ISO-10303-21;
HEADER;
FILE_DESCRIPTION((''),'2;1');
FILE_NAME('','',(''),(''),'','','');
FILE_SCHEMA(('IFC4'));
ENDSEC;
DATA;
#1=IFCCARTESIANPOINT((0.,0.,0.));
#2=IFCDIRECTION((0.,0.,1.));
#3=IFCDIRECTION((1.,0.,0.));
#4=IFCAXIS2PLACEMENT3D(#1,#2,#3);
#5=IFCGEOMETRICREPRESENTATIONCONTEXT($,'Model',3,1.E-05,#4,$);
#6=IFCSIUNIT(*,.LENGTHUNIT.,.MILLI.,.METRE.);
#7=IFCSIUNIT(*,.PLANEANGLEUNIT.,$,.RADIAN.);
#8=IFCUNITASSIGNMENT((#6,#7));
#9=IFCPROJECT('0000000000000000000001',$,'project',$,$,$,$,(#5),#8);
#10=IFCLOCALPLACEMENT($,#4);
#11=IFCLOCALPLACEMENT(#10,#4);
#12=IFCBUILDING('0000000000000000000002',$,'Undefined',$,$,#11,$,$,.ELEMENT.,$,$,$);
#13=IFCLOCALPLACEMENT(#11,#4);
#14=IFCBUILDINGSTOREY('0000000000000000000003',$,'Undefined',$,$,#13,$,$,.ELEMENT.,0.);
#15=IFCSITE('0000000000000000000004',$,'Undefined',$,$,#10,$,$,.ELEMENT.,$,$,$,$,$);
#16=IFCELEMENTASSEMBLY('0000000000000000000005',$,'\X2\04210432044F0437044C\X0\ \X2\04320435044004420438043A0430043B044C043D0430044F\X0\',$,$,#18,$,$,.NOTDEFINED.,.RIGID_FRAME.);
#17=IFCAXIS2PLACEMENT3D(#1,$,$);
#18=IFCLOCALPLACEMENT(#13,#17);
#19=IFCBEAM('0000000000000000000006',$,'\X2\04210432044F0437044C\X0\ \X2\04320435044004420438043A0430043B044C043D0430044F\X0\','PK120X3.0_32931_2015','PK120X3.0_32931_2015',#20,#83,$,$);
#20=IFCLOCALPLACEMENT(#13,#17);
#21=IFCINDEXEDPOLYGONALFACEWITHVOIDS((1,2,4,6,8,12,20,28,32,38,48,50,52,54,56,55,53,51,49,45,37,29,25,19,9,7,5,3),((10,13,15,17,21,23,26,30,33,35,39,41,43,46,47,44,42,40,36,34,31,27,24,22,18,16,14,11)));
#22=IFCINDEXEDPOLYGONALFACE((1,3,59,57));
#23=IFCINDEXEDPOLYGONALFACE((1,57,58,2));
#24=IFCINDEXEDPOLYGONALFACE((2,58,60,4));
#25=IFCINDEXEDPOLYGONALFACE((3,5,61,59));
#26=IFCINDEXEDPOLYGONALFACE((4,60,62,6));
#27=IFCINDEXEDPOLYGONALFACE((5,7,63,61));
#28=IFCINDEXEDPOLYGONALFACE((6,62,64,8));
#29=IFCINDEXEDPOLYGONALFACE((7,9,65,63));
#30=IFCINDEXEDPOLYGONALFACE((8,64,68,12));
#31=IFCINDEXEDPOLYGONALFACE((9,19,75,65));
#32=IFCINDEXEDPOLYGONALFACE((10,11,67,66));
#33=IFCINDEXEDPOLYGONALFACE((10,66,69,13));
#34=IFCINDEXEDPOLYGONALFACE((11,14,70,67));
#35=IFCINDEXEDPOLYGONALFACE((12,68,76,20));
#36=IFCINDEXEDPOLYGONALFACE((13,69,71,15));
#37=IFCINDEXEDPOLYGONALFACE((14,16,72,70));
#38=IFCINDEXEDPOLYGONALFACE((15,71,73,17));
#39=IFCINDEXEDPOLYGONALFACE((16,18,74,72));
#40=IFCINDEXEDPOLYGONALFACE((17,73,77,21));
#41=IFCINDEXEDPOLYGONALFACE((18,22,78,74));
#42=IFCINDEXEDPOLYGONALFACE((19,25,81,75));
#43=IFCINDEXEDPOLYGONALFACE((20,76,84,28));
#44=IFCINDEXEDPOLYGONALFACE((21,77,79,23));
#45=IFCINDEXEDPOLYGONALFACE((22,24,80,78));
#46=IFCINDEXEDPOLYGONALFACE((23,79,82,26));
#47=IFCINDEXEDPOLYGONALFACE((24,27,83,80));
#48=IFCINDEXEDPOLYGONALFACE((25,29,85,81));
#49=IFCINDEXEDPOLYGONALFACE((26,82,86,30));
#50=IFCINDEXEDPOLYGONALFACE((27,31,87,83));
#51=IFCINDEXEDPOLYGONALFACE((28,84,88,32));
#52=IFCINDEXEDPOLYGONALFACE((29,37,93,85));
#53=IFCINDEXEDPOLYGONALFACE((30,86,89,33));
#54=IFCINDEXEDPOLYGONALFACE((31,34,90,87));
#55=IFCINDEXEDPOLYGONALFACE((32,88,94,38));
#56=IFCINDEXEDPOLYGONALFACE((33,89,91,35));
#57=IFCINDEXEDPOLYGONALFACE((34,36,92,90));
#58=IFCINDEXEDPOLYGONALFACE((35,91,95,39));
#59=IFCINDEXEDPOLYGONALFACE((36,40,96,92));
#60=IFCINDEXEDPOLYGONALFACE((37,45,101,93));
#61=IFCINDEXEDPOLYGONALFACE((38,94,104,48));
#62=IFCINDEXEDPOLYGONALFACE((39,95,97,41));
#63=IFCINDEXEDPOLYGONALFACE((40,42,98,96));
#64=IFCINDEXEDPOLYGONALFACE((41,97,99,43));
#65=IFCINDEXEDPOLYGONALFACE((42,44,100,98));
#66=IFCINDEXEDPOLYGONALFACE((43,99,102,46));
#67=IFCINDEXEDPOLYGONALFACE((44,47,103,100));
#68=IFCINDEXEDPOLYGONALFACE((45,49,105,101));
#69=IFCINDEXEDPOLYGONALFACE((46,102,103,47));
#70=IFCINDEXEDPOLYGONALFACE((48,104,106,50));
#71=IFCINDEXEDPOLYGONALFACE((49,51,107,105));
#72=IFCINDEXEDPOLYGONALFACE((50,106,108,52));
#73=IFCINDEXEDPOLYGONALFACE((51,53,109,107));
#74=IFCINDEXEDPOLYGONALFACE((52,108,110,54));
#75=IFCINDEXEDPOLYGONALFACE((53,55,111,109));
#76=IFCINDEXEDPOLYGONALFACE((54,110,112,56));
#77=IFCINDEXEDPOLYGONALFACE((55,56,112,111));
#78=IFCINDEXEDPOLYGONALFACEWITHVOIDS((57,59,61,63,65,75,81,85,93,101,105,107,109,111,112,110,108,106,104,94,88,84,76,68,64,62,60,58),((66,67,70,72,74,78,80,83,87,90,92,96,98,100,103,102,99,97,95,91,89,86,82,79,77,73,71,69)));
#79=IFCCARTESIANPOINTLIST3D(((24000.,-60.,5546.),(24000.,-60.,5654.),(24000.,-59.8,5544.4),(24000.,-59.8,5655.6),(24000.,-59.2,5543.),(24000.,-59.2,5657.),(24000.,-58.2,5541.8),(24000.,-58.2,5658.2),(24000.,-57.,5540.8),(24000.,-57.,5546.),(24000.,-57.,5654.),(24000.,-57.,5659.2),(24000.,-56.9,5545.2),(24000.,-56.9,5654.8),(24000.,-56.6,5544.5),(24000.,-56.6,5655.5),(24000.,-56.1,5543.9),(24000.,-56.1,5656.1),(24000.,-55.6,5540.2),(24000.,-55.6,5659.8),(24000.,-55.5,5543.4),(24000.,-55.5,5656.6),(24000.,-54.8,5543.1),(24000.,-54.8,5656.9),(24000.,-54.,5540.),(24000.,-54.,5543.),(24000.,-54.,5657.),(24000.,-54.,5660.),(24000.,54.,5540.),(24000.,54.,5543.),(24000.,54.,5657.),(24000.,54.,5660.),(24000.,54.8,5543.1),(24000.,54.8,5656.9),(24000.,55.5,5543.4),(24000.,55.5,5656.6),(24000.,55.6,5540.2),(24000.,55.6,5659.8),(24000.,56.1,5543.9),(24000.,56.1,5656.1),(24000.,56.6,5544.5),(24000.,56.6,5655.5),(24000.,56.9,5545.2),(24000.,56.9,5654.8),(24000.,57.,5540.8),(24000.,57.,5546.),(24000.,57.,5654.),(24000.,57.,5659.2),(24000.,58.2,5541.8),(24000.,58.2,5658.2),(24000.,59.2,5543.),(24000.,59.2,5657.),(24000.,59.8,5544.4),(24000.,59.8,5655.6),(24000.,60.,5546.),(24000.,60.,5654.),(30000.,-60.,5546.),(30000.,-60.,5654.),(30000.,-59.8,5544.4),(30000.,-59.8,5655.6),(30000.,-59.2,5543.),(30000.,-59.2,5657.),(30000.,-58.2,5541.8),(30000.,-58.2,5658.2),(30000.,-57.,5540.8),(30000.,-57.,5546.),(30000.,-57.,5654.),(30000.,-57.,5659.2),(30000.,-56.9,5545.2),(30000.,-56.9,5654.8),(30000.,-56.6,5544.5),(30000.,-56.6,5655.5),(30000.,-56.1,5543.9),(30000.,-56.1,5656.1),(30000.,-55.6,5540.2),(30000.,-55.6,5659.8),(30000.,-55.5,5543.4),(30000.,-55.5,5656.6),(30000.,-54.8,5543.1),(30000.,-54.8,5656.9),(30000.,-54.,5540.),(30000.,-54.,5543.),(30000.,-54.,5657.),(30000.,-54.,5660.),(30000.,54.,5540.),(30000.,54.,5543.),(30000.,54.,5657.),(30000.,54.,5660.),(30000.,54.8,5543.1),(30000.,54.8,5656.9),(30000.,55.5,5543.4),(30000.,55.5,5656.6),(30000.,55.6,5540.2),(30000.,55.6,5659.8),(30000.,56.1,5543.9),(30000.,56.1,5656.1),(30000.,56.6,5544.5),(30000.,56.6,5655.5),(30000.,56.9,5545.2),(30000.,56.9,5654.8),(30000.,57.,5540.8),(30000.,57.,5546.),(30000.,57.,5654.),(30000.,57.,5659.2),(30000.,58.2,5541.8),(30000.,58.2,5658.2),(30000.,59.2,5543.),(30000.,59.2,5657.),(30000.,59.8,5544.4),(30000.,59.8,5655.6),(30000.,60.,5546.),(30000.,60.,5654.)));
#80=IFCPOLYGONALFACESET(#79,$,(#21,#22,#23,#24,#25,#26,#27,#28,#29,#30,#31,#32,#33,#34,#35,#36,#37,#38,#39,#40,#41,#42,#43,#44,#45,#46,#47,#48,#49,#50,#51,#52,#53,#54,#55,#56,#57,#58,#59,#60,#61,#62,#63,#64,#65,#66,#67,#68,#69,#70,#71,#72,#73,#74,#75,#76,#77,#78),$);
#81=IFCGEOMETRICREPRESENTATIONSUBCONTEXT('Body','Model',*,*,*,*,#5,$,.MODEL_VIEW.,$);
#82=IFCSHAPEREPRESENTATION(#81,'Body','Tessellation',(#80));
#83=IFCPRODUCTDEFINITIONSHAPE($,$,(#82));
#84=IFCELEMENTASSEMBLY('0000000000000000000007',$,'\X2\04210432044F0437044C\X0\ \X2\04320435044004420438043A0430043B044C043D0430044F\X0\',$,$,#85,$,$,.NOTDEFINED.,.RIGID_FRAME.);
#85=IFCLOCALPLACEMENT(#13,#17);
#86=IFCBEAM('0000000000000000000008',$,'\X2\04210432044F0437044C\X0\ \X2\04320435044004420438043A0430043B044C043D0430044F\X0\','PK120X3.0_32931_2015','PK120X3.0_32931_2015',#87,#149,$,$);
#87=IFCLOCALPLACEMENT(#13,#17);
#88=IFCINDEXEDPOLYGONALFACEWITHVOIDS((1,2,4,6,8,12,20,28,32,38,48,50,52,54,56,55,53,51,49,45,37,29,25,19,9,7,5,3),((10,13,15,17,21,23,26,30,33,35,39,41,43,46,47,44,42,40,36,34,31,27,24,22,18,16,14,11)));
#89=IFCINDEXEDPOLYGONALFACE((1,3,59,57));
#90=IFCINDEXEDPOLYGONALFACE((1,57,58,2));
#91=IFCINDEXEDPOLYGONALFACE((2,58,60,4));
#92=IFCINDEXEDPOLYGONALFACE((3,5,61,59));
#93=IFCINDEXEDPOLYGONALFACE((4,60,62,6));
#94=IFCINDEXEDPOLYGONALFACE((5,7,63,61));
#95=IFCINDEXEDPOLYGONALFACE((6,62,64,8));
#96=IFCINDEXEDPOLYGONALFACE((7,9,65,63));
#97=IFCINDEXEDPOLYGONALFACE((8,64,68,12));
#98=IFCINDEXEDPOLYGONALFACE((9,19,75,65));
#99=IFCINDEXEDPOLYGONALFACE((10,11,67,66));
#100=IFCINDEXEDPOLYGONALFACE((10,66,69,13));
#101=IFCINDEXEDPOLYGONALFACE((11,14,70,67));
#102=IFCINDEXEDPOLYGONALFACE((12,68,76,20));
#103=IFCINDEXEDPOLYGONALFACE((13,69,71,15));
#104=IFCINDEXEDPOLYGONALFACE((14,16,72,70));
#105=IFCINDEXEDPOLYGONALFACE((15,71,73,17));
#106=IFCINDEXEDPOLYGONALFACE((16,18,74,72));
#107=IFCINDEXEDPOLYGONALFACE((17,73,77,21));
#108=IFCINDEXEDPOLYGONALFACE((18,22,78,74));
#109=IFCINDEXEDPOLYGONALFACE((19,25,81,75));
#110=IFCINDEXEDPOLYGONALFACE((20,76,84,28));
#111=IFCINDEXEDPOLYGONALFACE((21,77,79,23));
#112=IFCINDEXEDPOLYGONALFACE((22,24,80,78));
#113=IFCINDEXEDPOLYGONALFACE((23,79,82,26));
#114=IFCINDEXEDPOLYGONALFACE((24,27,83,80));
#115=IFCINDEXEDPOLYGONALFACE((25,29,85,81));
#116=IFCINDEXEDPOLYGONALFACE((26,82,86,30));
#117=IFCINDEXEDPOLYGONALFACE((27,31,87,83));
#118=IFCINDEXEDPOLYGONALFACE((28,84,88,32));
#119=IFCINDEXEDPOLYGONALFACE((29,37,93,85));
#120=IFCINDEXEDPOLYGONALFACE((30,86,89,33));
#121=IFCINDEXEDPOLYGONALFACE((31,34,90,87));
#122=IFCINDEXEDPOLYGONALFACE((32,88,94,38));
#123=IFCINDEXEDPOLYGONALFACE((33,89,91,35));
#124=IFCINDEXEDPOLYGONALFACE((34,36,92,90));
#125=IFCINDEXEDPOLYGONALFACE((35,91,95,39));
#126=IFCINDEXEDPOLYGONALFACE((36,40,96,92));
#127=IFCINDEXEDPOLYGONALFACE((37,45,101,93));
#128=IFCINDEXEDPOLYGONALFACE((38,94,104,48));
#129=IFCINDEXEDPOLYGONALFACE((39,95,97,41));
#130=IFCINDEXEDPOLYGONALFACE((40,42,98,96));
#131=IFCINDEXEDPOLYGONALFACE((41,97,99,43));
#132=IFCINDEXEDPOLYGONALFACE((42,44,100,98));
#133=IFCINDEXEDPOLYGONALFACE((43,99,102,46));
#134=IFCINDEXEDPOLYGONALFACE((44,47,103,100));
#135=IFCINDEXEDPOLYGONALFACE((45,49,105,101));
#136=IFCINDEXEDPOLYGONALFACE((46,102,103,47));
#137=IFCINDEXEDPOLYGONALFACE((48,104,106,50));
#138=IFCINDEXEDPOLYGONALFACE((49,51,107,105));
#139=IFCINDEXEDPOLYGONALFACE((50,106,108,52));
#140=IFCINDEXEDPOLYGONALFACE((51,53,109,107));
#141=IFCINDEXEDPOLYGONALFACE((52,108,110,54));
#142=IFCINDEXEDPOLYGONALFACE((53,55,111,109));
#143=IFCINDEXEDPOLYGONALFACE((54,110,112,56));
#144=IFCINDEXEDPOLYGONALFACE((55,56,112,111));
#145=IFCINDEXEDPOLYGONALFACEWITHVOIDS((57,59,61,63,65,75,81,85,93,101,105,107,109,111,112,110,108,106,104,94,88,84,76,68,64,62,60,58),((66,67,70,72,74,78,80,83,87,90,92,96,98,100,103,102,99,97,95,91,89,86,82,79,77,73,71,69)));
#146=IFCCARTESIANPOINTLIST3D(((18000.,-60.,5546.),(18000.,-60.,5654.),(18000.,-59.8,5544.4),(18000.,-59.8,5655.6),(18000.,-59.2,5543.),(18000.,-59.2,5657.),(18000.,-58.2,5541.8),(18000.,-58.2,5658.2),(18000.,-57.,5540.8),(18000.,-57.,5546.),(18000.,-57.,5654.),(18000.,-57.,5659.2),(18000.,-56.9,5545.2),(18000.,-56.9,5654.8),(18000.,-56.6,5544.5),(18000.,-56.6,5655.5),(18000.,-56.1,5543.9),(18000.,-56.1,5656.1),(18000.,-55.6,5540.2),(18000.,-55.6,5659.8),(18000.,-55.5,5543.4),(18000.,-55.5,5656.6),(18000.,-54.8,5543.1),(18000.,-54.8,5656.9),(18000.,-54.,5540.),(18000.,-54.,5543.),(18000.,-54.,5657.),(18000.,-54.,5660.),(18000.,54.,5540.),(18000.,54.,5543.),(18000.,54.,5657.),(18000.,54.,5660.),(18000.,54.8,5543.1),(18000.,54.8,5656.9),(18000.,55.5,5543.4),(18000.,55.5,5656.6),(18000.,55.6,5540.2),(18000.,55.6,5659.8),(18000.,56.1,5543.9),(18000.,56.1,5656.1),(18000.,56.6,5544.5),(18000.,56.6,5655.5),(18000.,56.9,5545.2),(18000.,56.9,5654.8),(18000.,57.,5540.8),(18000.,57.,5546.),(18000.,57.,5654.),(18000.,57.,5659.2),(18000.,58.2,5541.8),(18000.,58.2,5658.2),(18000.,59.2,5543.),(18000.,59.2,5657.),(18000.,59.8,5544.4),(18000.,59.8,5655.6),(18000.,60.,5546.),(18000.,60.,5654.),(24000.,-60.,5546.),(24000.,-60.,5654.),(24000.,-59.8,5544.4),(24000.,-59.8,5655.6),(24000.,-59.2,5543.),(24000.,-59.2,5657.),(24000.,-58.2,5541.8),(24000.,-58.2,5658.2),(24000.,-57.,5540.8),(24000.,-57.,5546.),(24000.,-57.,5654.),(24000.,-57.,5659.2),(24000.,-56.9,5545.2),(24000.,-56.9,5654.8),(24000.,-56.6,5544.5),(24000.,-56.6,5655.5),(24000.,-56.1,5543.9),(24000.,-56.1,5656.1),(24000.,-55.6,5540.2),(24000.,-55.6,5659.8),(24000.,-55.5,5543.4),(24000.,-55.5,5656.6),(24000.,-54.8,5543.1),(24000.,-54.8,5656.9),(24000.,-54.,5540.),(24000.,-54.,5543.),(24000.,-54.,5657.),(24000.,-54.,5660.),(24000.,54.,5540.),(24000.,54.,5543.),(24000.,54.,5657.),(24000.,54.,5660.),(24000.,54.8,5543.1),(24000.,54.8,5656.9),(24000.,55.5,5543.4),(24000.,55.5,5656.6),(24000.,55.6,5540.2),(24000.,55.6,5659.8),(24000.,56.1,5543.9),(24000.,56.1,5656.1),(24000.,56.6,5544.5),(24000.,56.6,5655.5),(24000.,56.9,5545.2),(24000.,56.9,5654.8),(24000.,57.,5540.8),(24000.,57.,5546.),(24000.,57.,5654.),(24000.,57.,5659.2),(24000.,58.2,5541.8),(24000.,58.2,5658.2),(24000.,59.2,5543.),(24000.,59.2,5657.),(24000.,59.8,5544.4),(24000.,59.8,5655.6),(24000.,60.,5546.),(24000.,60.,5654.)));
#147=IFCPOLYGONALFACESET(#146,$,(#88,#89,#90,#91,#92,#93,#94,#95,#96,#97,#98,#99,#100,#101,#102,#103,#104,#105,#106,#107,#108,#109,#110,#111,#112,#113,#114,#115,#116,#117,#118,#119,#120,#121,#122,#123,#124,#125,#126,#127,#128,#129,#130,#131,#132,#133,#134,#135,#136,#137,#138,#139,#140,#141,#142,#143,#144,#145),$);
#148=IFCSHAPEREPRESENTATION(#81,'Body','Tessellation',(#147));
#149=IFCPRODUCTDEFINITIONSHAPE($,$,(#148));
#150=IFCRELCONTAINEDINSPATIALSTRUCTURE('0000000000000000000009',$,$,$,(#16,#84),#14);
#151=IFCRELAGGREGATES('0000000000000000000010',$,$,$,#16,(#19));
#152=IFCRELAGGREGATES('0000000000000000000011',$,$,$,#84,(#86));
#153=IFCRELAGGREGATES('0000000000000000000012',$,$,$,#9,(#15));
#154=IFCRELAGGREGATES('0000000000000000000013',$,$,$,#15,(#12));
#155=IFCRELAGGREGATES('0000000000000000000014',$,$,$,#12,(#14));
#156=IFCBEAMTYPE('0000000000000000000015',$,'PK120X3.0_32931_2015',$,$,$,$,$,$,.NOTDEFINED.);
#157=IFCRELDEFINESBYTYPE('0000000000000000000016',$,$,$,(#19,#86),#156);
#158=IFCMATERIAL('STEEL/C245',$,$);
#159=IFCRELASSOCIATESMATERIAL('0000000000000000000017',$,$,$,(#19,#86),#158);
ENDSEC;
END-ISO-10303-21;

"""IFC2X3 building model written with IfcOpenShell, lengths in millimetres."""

from ifc_helpers import new_model, si_unit, frame, origin_with_axes, origin_2d_with_axis, place, context, subcontext, project, spatial, hollow_rectangle, extrude, material, type_object, element, aggregate, save


model = new_model("IFC2X3")

# Units and contexts
model_context = context("Model", 3, precision=1e-05, world=origin_with_axes())
body_context = subcontext(model_context, "Body", "Model", "MODEL_VIEW")
ifc_project = project(units=[si_unit("LENGTHUNIT", "METRE", prefix="MILLI"), si_unit("PLANEANGLEUNIT", "RADIAN")], contexts=[model_context])

# Site, building, storey
site_placement = place(None, origin_with_axes())
site = spatial("IfcSite", under=ifc_project, at=site_placement, Name="Undefined", CompositionType="ELEMENT")
building_placement = place(site_placement, origin_with_axes())
building = spatial("IfcBuilding", under=site, at=building_placement, Name="Undefined", CompositionType="ELEMENT")
storey_placement = place(building_placement, origin_with_axes())
storey = spatial("IfcBuildingStorey", under=building, at=storey_placement, Name="Undefined", CompositionType="ELEMENT", Elevation=0.0)

# Shared definitions
ifc_material_1 = material(Name="STEEL/C245")

# Element assemblies, beams
beam_type_1 = type_object("IfcBeamType", Name="PK120X3.0_32931_2015", PredefinedType="NOTDEFINED")
assembly_1_placement = place(storey_placement, origin_with_axes())
assembly_1 = element("IfcElementAssembly", 1, at=assembly_1_placement, inside=storey, Name="Связь вертикальная", AssemblyPlace="NOTDEFINED", PredefinedType="RIGID_FRAME")
beam_1_placement = place(assembly_1_placement, frame((24000.0, 0.0, 5600.0), z_axis=(0.0, 0.0, 1.0), x_axis=(1.0, 0.0, 0.0)))
beam_1 = element("IfcBeam", 2, at=beam_1_placement, type_object=beam_type_1, material=ifc_material_1, Name="Связь вертикальная", Description="PK120X3.0_32931_2015", ObjectType="PK120X3.0_32931_2015", context=body_context, shape_type="SweptSolid", body=[
    extrude(hollow_rectangle(XDim=120.0, YDim=120.0, WallThickness=3.0, InnerFilletRadius=3.0, OuterFilletRadius=6.0, at=origin_2d_with_axis()), frame((6000.0, 0.0, 0.0), z_axis=(-1.0, 0.0, 0.0), x_axis=(0.0, -1.0, 0.0)), (0.0, 0.0, 1.0), 6000.0),
])
aggregate(assembly_1, [beam_1])
assembly_2_placement = place(storey_placement, origin_with_axes())
assembly_2 = element("IfcElementAssembly", 3, at=assembly_2_placement, inside=storey, Name="Связь вертикальная", AssemblyPlace="NOTDEFINED", PredefinedType="RIGID_FRAME")
beam_2_placement = place(assembly_2_placement, frame((18000.0, 0.0, 5600.0), z_axis=(0.0, 0.0, 1.0), x_axis=(1.0, 0.0, 0.0)))
beam_2 = element("IfcBeam", 4, at=beam_2_placement, type_object=beam_type_1, material=ifc_material_1, Name="Связь вертикальная", Description="PK120X3.0_32931_2015", ObjectType="PK120X3.0_32931_2015", context=body_context, shape_type="SweptSolid", body=[
    extrude(hollow_rectangle(XDim=120.0, YDim=120.0, WallThickness=3.0, InnerFilletRadius=3.0, OuterFilletRadius=6.0, at=origin_2d_with_axis()), frame((6000.0, 0.0, 0.0), z_axis=(-1.0, 0.0, 0.0), x_axis=(0.0, -1.0, 0.0)), (0.0, 0.0, 1.0), 6000.0),
])
aggregate(assembly_2, [beam_2])

save(model, "model.ifc")
